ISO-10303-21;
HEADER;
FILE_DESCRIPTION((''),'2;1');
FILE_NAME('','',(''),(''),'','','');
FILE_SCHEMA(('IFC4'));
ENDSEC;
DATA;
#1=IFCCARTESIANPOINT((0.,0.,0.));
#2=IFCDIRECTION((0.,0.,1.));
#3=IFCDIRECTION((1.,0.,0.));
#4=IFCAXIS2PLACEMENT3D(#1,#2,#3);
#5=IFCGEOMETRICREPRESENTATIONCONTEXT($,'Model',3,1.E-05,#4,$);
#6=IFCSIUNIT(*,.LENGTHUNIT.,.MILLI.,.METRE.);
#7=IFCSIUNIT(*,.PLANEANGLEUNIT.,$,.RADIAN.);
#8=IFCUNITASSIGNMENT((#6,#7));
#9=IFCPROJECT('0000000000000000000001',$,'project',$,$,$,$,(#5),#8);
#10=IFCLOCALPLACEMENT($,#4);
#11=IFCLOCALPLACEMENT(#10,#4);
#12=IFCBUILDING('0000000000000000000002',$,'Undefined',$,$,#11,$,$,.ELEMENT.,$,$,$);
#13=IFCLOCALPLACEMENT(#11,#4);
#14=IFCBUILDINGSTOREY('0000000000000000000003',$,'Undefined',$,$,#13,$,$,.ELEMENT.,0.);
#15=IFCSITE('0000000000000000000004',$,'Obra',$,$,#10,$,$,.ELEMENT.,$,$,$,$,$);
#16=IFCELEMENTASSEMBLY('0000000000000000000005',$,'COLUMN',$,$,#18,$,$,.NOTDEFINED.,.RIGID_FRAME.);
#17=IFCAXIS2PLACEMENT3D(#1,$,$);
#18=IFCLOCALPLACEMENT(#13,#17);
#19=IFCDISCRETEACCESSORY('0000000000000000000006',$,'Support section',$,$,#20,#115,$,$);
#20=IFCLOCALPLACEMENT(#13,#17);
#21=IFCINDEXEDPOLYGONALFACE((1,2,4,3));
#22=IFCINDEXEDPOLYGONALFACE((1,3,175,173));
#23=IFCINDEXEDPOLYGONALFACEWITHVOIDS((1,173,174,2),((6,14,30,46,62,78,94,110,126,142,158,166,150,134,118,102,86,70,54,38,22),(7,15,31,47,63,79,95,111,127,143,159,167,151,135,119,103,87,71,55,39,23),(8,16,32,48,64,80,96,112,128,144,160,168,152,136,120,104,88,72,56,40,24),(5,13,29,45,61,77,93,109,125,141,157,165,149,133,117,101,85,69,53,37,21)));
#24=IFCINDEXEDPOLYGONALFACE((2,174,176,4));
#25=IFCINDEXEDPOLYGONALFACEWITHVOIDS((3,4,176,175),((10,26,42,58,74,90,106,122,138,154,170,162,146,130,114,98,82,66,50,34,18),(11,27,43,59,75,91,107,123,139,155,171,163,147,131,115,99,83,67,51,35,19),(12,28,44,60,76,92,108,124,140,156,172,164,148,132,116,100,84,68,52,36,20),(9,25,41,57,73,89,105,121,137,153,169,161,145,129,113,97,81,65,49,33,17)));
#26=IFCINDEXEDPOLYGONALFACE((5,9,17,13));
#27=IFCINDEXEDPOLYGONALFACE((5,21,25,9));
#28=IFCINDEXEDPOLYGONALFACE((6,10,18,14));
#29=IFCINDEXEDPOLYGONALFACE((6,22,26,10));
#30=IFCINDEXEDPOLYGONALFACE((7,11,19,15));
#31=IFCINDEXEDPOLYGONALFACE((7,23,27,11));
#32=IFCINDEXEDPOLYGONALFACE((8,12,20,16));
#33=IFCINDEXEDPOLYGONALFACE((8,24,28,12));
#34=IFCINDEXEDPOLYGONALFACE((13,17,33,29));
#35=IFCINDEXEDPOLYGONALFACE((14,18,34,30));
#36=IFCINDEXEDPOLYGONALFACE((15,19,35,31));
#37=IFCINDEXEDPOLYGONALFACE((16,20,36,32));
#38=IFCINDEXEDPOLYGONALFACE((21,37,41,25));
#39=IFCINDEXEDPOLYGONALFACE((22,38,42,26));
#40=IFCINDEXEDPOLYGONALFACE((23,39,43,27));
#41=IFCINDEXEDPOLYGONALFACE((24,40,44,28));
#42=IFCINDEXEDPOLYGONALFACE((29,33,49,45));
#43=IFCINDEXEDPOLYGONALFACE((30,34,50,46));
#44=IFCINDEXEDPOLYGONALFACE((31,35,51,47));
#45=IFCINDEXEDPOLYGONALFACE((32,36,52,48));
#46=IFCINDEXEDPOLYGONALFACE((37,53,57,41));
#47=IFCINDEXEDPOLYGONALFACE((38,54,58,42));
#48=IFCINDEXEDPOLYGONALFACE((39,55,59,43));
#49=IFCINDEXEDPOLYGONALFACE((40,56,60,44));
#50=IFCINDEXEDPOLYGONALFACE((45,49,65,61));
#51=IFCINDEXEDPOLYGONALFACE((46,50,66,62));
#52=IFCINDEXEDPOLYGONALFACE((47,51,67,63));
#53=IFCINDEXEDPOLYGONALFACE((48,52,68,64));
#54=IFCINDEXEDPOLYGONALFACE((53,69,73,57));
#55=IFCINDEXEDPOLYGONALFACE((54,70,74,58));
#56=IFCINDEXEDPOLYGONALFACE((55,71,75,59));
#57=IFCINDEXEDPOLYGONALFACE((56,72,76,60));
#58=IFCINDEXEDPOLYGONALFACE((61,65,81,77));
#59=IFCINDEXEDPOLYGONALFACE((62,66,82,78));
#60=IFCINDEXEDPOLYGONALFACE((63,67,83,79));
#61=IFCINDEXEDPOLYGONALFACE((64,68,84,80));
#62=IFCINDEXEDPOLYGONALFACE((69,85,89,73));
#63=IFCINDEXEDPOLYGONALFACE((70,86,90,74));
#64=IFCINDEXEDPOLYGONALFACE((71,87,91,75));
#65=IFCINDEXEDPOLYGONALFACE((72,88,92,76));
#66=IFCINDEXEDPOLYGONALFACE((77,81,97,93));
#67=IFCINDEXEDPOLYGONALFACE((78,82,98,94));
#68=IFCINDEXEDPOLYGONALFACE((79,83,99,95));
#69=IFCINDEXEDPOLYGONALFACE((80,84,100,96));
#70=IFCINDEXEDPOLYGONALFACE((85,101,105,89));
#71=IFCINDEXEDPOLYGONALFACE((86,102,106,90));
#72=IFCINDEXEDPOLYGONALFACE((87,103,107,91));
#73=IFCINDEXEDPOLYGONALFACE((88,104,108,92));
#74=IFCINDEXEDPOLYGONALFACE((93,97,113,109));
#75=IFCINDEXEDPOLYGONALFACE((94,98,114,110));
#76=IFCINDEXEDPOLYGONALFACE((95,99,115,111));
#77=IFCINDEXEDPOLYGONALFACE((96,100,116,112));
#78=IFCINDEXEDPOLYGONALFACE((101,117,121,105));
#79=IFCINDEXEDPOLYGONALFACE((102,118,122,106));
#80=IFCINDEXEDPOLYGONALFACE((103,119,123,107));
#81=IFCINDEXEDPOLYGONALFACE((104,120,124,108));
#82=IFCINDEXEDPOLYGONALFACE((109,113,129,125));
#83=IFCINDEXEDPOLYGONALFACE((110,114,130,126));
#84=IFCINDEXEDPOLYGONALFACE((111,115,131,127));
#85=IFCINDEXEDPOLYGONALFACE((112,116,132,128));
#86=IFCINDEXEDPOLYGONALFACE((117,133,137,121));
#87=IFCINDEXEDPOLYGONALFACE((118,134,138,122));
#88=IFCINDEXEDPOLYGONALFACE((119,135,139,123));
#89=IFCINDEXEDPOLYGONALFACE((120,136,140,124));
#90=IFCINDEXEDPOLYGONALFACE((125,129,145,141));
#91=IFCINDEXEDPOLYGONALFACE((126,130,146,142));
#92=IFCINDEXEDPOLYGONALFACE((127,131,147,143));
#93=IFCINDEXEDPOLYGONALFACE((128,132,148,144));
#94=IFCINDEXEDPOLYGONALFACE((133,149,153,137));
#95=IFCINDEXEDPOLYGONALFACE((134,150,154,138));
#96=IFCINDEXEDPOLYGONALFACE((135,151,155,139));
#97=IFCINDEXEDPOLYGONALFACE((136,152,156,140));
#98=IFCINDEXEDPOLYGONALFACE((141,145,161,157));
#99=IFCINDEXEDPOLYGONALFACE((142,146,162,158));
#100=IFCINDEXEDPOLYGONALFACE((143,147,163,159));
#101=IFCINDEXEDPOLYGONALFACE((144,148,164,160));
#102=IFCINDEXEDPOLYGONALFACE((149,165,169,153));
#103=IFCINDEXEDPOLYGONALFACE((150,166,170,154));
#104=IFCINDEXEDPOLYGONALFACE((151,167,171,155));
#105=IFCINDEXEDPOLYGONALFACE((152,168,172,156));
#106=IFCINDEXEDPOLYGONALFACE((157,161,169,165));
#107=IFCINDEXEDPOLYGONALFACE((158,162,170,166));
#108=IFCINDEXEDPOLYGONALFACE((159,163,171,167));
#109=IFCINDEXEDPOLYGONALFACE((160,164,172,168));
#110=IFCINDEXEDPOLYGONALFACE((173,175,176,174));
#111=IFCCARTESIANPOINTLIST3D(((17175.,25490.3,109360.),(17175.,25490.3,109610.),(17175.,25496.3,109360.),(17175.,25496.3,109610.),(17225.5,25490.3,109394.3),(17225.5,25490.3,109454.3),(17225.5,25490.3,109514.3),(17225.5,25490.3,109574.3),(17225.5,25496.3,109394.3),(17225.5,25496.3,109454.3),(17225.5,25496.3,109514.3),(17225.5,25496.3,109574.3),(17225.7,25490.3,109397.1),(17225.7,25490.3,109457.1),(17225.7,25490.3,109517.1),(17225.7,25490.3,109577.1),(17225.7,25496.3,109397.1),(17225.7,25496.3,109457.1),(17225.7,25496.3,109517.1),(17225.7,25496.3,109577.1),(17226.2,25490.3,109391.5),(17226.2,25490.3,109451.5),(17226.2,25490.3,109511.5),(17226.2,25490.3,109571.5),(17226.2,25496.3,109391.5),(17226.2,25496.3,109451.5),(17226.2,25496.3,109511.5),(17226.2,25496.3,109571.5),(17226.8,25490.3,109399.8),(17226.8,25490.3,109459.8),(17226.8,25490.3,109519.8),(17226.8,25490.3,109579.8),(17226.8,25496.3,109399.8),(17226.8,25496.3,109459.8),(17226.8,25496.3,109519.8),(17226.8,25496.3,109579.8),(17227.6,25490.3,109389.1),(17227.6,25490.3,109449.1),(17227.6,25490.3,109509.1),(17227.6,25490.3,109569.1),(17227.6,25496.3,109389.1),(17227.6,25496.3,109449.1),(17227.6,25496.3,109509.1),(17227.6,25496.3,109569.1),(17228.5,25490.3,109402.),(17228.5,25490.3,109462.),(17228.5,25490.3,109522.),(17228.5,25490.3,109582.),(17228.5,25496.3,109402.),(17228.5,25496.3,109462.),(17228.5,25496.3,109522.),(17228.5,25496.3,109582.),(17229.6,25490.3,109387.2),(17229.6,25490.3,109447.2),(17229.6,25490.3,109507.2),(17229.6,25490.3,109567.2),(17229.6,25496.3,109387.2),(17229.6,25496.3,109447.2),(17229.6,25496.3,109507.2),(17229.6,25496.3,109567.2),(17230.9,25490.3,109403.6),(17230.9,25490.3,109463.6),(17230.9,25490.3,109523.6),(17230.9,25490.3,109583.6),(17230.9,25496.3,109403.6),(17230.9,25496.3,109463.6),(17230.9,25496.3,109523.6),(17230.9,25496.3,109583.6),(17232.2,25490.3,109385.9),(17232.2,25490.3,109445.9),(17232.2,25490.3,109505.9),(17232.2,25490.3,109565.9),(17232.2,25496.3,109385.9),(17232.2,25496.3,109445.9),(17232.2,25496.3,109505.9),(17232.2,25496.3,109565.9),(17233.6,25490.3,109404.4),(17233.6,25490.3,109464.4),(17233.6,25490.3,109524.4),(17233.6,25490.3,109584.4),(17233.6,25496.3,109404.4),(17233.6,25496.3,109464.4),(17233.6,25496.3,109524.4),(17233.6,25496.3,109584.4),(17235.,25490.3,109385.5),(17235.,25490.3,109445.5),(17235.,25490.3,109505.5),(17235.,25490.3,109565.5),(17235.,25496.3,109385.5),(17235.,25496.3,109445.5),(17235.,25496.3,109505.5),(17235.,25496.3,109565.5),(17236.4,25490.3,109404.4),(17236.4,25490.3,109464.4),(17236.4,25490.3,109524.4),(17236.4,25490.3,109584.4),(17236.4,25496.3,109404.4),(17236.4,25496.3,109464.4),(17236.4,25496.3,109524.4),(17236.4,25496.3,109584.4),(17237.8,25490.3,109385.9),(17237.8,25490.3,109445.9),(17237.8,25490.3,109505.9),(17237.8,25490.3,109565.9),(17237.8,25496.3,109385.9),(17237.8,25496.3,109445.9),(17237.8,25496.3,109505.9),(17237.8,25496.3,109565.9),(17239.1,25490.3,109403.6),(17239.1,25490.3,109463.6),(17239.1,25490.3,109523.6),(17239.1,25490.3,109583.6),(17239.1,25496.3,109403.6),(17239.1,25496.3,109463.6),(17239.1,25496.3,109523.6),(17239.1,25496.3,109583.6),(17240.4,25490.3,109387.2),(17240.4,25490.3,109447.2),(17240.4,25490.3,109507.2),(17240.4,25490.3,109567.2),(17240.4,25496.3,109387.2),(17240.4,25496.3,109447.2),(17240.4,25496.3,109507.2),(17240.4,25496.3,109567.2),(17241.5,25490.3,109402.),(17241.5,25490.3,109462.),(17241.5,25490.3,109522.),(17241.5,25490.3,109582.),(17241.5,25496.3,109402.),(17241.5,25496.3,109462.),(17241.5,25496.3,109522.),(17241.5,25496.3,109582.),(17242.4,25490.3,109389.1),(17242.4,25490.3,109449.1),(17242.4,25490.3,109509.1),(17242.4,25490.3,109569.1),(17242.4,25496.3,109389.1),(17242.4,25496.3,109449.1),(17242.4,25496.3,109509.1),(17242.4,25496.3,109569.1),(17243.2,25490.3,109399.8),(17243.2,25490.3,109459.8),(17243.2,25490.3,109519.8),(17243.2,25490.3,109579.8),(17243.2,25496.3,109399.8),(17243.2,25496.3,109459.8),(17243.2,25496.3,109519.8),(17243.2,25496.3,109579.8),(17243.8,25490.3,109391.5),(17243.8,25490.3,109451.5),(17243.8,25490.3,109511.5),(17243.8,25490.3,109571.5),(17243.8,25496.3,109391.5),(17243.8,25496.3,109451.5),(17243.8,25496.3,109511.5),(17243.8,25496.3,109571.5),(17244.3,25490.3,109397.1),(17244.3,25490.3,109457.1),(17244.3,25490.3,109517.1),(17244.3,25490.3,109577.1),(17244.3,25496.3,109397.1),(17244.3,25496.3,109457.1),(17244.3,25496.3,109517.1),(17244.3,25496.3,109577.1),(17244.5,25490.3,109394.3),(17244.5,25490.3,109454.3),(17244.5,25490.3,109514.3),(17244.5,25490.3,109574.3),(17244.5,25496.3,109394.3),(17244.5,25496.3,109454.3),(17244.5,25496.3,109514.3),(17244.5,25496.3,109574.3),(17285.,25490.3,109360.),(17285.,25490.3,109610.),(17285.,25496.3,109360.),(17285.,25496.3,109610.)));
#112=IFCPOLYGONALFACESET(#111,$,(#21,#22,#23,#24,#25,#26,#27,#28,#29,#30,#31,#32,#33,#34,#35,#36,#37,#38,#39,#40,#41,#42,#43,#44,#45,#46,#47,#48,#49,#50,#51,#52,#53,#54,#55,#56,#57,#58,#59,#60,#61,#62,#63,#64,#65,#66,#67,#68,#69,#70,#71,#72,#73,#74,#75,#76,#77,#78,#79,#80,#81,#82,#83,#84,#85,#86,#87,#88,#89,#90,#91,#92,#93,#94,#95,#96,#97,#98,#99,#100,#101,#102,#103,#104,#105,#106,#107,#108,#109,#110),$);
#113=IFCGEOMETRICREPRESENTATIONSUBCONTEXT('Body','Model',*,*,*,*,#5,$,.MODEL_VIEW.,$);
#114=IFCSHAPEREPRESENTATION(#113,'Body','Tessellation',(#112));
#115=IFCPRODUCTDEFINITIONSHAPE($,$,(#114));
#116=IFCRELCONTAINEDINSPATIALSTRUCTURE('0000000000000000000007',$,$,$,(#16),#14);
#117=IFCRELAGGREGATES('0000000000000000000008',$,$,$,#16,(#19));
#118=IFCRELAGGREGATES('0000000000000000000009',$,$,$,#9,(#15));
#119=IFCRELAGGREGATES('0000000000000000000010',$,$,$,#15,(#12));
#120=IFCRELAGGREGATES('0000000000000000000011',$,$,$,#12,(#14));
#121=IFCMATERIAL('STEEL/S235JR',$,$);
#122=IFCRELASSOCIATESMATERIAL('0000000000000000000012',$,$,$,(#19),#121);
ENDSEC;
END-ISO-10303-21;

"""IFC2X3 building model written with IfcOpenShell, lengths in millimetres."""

from ifc_helpers import new_model, si_unit, frame, origin_with_axes, origin_2d_with_axis, place, context, subcontext, project, spatial, rectangle, circle, extrude, source, transform, mapped, material, element, aggregate, save


model = new_model("IFC2X3")

# Units and contexts
model_context = context("Model", 3, precision=1e-05, world=origin_with_axes())
body_context = subcontext(model_context, "Body", "Model", "MODEL_VIEW")
ifc_project = project(units=[si_unit("LENGTHUNIT", "METRE", prefix="MILLI"), si_unit("PLANEANGLEUNIT", "RADIAN")], contexts=[model_context])

# Site, building, storey
site_placement = place(None, origin_with_axes())
site = spatial("IfcSite", under=ifc_project, at=site_placement, Name="Obra", CompositionType="ELEMENT")
building_placement = place(site_placement, origin_with_axes())
building = spatial("IfcBuilding", under=site, at=building_placement, Name="Undefined", CompositionType="ELEMENT")
storey_placement = place(building_placement, origin_with_axes())
storey = spatial("IfcBuildingStorey", under=building, at=storey_placement, Name="Undefined", CompositionType="ELEMENT", Elevation=0.0)

# Element assembly, discrete accessory, opening
ifc_material_1 = material(Name="STEEL/S235JR")
shared_shape_1 = source(origin_with_axes(), body_context, "Body", "SweptSolid", [
    extrude(circle(Radius=9.5, at=origin_2d_with_axis()), frame((0.0, -9.8, 0.0), z_axis=(0.0, 1.0, 0.0), x_axis=(1.0, 0.0, 0.0)), (0.0, 0.0, 1.0), 6.2),
])
assembly_1_placement = place(storey_placement, origin_with_axes())
assembly_1 = element("IfcElementAssembly", 1, at=assembly_1_placement, inside=storey, Name="COLUMN", AssemblyPlace="NOTDEFINED", PredefinedType="RIGID_FRAME")
discrete_accessory_1_placement = place(assembly_1_placement, frame((17230.0, 25493.3, 109360.0), z_axis=(0.0, 0.0, 1.0), x_axis=(-1.0, 0.0, 0.0)))
discrete_accessory_1 = element("IfcDiscreteAccessory", 2, at=discrete_accessory_1_placement, material=ifc_material_1, Name="Support section", context=body_context, shape_type="SweptSolid", body=[
    extrude(rectangle(XDim=6.0, YDim=110.0, at=origin_2d_with_axis()), frame((0.0, 0.0, 250.0), z_axis=(0.0, 0.0, -1.0), x_axis=(0.0, 1.0, 0.0)), (0.0, 0.0, 1.0), 250.0),
])
opening_1_placement = place(assembly_1_placement, frame((17185.0, 25500.0, 109650.0), z_axis=(1.0, 0.0, 0.0), x_axis=(0.0, 0.0, -1.0)))
element("IfcOpeningElement", 3, at=opening_1_placement, cuts=discrete_accessory_1, ObjectType="Opening", context=body_context, shape_type="MappedRepresentation", body=[
    mapped(shared_shape_1, transform((75.0, 0.0, 50.0))),
    mapped(shared_shape_1, transform((135.0, 0.0, 50.0))),
    mapped(shared_shape_1, transform((195.0, 0.0, 50.0))),
    mapped(shared_shape_1, transform((255.0, 0.0, 50.0))),
])
aggregate(assembly_1, [discrete_accessory_1])

save(model, "model.ifc")
